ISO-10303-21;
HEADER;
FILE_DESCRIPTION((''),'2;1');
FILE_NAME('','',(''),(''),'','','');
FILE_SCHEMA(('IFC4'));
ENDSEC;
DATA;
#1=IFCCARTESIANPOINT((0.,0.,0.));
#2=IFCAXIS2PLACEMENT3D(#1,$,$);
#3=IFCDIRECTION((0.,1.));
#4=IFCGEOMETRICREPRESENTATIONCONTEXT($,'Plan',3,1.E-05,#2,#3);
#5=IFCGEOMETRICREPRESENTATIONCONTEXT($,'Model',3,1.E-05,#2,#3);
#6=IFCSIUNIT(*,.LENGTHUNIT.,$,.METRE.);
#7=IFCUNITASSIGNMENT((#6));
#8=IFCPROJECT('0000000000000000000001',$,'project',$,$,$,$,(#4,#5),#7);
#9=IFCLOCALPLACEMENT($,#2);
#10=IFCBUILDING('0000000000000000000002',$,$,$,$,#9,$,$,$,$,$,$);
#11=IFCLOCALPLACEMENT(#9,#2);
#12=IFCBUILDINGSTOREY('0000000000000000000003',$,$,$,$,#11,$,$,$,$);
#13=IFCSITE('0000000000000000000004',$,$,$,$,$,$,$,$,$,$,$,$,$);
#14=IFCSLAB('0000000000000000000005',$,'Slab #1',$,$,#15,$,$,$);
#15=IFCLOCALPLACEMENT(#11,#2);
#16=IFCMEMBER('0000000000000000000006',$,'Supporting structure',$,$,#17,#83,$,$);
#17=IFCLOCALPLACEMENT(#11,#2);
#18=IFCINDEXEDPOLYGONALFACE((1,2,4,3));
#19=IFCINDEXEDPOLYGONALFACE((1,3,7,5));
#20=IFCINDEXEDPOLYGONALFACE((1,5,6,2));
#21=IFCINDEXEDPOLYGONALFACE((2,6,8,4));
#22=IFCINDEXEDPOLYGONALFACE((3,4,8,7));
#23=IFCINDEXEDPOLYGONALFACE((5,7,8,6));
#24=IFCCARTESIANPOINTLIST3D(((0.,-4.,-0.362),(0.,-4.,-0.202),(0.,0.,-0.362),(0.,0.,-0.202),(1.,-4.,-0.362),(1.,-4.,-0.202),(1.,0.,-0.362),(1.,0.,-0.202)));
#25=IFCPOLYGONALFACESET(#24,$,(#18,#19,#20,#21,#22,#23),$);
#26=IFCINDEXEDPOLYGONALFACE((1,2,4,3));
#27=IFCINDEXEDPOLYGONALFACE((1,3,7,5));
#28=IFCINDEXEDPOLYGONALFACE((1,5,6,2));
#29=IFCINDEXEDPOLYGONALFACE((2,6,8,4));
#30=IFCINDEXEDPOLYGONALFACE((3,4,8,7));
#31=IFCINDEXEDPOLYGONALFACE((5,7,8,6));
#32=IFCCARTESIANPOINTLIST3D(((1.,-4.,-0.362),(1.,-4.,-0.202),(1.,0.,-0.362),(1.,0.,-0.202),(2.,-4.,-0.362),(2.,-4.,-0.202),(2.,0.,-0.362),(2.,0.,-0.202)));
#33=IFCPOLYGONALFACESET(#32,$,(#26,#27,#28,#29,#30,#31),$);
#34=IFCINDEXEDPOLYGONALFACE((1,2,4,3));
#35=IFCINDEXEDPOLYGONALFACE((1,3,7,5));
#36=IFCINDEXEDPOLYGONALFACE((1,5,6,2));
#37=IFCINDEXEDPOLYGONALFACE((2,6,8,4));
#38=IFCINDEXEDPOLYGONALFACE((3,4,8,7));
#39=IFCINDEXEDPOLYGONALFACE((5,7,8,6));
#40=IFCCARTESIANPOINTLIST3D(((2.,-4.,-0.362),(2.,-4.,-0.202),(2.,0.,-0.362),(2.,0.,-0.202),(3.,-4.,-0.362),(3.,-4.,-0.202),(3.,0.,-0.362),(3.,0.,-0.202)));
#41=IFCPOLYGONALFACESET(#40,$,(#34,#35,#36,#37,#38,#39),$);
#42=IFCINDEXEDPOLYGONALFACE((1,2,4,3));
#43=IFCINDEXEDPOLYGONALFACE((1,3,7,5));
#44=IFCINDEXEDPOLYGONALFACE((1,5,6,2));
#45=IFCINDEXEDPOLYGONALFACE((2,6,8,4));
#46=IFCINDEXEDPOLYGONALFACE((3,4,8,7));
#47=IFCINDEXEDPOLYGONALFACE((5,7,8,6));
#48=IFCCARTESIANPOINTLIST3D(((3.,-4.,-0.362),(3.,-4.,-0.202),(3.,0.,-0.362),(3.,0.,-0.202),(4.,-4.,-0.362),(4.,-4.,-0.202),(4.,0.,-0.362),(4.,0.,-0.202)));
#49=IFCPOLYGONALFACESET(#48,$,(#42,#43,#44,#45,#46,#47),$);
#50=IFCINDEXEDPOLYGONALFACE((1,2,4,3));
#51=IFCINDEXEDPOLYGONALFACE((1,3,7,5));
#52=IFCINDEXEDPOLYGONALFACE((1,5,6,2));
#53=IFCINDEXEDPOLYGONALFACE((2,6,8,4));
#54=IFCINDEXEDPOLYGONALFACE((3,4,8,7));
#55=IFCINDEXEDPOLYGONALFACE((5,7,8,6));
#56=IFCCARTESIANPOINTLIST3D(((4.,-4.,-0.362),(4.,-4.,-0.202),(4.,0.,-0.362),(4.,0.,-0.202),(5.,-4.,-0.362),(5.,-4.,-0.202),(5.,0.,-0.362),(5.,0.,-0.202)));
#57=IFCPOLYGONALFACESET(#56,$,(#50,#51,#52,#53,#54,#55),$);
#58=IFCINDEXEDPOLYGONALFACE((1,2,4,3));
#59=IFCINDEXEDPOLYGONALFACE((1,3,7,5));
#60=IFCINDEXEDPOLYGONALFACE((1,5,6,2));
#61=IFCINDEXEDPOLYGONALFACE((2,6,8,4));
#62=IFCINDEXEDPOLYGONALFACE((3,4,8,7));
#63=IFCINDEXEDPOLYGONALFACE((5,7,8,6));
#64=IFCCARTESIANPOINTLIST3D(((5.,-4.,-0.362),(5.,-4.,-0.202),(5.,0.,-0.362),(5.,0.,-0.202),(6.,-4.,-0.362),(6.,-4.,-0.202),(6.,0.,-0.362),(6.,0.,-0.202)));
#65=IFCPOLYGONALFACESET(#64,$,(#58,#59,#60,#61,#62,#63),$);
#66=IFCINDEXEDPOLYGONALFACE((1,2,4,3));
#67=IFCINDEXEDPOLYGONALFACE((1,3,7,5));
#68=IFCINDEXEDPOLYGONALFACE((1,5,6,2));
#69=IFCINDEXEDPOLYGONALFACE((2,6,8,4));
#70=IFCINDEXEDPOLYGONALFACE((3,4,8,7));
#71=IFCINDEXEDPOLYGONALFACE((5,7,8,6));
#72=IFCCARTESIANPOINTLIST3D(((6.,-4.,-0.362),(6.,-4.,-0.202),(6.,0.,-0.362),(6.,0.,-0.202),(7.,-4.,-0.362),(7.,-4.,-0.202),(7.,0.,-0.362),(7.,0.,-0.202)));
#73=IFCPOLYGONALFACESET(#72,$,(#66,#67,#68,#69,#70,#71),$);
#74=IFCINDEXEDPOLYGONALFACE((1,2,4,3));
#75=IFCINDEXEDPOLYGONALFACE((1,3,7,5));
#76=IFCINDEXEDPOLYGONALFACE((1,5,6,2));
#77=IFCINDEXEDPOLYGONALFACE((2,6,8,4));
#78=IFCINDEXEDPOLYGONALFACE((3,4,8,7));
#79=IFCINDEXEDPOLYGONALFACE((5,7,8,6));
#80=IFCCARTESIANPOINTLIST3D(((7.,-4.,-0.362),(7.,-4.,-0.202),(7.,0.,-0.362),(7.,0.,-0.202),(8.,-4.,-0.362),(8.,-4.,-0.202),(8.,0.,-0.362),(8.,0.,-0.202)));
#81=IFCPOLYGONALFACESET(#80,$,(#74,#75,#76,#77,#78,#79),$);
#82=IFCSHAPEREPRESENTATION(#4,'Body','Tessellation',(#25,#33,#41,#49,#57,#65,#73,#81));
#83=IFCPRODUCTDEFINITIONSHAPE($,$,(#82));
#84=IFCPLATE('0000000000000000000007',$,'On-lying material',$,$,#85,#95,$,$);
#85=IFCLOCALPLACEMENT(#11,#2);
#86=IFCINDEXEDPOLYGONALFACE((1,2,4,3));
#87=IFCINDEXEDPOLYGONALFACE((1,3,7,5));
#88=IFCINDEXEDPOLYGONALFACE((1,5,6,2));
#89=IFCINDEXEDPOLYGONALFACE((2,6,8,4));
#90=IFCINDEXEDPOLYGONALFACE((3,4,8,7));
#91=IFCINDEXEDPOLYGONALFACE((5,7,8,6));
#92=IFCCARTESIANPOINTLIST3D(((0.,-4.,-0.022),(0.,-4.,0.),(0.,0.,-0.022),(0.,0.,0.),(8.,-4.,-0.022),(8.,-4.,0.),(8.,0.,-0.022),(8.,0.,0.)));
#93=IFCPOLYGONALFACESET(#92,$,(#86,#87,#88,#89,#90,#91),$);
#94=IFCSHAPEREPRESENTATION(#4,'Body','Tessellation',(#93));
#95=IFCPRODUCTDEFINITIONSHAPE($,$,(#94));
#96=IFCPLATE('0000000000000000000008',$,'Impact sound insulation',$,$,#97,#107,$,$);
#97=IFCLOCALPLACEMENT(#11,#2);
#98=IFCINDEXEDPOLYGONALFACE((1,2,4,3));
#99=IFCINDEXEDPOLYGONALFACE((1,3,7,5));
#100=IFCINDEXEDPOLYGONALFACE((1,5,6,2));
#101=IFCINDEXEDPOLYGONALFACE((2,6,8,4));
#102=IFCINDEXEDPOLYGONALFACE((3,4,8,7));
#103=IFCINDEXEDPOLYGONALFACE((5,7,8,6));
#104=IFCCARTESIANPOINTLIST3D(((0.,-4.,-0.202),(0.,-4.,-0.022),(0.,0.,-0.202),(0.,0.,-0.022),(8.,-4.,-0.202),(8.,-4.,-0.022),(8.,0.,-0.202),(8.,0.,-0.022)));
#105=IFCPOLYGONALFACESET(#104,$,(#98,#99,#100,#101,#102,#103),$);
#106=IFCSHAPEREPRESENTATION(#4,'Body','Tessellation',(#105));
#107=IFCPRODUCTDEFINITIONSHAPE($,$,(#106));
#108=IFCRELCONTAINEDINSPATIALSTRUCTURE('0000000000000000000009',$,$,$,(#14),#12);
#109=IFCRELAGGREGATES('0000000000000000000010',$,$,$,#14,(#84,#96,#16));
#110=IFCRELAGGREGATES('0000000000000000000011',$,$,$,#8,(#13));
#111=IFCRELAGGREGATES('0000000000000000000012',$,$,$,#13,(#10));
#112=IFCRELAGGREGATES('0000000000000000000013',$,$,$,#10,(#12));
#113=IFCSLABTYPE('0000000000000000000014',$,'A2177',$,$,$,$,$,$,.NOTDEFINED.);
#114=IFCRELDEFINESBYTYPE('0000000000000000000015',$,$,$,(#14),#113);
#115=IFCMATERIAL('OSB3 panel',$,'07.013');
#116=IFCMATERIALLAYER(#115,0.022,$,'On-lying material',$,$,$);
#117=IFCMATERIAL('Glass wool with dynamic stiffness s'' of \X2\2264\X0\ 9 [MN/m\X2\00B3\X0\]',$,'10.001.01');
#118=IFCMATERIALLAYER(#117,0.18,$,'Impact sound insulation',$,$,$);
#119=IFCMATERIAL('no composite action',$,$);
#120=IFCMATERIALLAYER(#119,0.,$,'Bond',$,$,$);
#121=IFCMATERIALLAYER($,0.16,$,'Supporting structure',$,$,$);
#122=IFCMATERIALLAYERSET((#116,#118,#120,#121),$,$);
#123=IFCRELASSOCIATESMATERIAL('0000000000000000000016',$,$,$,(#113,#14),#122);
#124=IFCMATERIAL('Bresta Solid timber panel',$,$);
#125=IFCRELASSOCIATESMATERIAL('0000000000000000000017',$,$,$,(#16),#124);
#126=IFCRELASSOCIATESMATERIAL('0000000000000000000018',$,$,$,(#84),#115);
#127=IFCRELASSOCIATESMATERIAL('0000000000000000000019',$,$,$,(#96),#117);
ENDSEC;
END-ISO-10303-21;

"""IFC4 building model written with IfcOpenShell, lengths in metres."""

from ifc_helpers import new_model, si_unit, direction, frame, frame_2d, origin, origin_with_axes, place, context, project, spatial, rectangle, extrude, material, layer, layer_set, type_object, element, aggregate, save


model = new_model("IFC4")

# Units and contexts
plan_context = context("Plan", 3, precision=1e-05, world=origin(), true_north=direction((0.0, 1.0)))
model_context = context("Model", 3, precision=1e-05, world=origin(), true_north=direction((0.0, 1.0)))
ifc_project = project(units=[si_unit("LENGTHUNIT", "METRE")], contexts=[plan_context, model_context])

# Site, building, storey
site = spatial("IfcSite", under=ifc_project)
building_placement = place(None, origin())
building = spatial("IfcBuilding", under=site, at=building_placement)
storey_placement = place(building_placement, origin())
storey = spatial("IfcBuildingStorey", under=building, at=storey_placement)

# Slab, member, plates
ifc_material_1 = material(Name="OSB3 panel", Category="07.013")
ifc_layer_1 = layer(ifc_material_1, 0.022, Name="On-lying material")
ifc_material_2 = material(Name="Glass wool with dynamic stiffness s' of ≤ 9 [MN/m³]", Category="10.001.01")
ifc_layer_2 = layer(ifc_material_2, 0.18, Name="Impact sound insulation")
ifc_material_3 = material(Name="no composite action")
ifc_layer_3 = layer(ifc_material_3, 0.0, Name="Bond")
ifc_layer_4 = layer(None, 0.16, Name="Supporting structure")
ifc_layer_set = layer_set([ifc_layer_1, ifc_layer_2, ifc_layer_3, ifc_layer_4])
slab_type = type_object("IfcSlabType", Name="A2177", PredefinedType="NOTDEFINED", material=ifc_layer_set)
slab_placement = place(None, frame((0.0, 0.0, 0.0), z_axis=(0.0, 0.0, -1.0), x_axis=(1.0, 0.0, 0.0)))
slab = element("IfcSlab", 1, at=slab_placement, inside=storey, type_object=slab_type, material=ifc_layer_set, Name="Slab #1")
ifc_material_4 = material(Name="Bresta Solid timber panel")
member_placement = place(slab_placement, origin())
member = element("IfcMember", 2, at=member_placement, material=ifc_material_4, Name="Supporting structure", context=plan_context, shape_type="SweptSolid", body=[
    extrude(rectangle(XDim=1.0, YDim=0.16, at=frame_2d((0.5, 0.08), x_axis=(1.0, 0.0))), frame((0.0, 4.0, 0.202), z_axis=(0.0, -1.0, 0.0), x_axis=(1.0, 0.0, 0.0)), (0.0, 0.0, 1.0), 4.0),
    extrude(rectangle(XDim=1.0, YDim=0.16, at=frame_2d((0.5, 0.08), x_axis=(1.0, 0.0))), frame((1.0, 4.0, 0.202), z_axis=(0.0, -1.0, 0.0), x_axis=(1.0, 0.0, 0.0)), (0.0, 0.0, 1.0), 4.0),
    extrude(rectangle(XDim=1.0, YDim=0.16, at=frame_2d((0.5, 0.08), x_axis=(1.0, 0.0))), frame((2.0, 4.0, 0.202), z_axis=(0.0, -1.0, 0.0), x_axis=(1.0, 0.0, 0.0)), (0.0, 0.0, 1.0), 4.0),
    extrude(rectangle(XDim=1.0, YDim=0.16, at=frame_2d((0.5, 0.08), x_axis=(1.0, 0.0))), frame((3.0, 4.0, 0.202), z_axis=(0.0, -1.0, 0.0), x_axis=(1.0, 0.0, 0.0)), (0.0, 0.0, 1.0), 4.0),
    extrude(rectangle(XDim=1.0, YDim=0.16, at=frame_2d((0.5, 0.08), x_axis=(1.0, 0.0))), frame((4.0, 4.0, 0.202), z_axis=(0.0, -1.0, 0.0), x_axis=(1.0, 0.0, 0.0)), (0.0, 0.0, 1.0), 4.0),
    extrude(rectangle(XDim=1.0, YDim=0.16, at=frame_2d((0.5, 0.08), x_axis=(1.0, 0.0))), frame((5.0, 4.0, 0.202), z_axis=(0.0, -1.0, 0.0), x_axis=(1.0, 0.0, 0.0)), (0.0, 0.0, 1.0), 4.0),
    extrude(rectangle(XDim=1.0, YDim=0.16, at=frame_2d((0.5, 0.08), x_axis=(1.0, 0.0))), frame((6.0, 4.0, 0.202), z_axis=(0.0, -1.0, 0.0), x_axis=(1.0, 0.0, 0.0)), (0.0, 0.0, 1.0), 4.0),
    extrude(rectangle(XDim=1.0, YDim=0.16, at=frame_2d((0.5, 0.08), x_axis=(1.0, 0.0))), frame((7.0, 4.0, 0.202), z_axis=(0.0, -1.0, 0.0), x_axis=(1.0, 0.0, 0.0)), (0.0, 0.0, 1.0), 4.0),
])
plate_1_placement = place(slab_placement, origin())
plate_1 = element("IfcPlate", 3, at=plate_1_placement, material=ifc_material_1, Name="On-lying material", context=plan_context, shape_type="SweptSolid", body=[
    extrude(rectangle(XDim=8.0, YDim=4.0, at=frame_2d((4.0, 2.0), x_axis=(1.0, 0.0))), origin_with_axes(), (0.0, 0.0, 1.0), 0.022),
])
plate_2_placement = place(slab_placement, origin())
plate_2 = element("IfcPlate", 4, at=plate_2_placement, material=ifc_material_2, Name="Impact sound insulation", context=plan_context, shape_type="SweptSolid", body=[
    extrude(rectangle(XDim=8.0, YDim=4.0, at=frame_2d((4.0, 2.0), x_axis=(1.0, 0.0))), frame((0.0, 0.0, 0.022), z_axis=(0.0, 0.0, 1.0), x_axis=(1.0, 0.0, 0.0)), (0.0, 0.0, 1.0), 0.18),
])
aggregate(slab, [plate_1, plate_2, member])

save(model, "model.ifc")
